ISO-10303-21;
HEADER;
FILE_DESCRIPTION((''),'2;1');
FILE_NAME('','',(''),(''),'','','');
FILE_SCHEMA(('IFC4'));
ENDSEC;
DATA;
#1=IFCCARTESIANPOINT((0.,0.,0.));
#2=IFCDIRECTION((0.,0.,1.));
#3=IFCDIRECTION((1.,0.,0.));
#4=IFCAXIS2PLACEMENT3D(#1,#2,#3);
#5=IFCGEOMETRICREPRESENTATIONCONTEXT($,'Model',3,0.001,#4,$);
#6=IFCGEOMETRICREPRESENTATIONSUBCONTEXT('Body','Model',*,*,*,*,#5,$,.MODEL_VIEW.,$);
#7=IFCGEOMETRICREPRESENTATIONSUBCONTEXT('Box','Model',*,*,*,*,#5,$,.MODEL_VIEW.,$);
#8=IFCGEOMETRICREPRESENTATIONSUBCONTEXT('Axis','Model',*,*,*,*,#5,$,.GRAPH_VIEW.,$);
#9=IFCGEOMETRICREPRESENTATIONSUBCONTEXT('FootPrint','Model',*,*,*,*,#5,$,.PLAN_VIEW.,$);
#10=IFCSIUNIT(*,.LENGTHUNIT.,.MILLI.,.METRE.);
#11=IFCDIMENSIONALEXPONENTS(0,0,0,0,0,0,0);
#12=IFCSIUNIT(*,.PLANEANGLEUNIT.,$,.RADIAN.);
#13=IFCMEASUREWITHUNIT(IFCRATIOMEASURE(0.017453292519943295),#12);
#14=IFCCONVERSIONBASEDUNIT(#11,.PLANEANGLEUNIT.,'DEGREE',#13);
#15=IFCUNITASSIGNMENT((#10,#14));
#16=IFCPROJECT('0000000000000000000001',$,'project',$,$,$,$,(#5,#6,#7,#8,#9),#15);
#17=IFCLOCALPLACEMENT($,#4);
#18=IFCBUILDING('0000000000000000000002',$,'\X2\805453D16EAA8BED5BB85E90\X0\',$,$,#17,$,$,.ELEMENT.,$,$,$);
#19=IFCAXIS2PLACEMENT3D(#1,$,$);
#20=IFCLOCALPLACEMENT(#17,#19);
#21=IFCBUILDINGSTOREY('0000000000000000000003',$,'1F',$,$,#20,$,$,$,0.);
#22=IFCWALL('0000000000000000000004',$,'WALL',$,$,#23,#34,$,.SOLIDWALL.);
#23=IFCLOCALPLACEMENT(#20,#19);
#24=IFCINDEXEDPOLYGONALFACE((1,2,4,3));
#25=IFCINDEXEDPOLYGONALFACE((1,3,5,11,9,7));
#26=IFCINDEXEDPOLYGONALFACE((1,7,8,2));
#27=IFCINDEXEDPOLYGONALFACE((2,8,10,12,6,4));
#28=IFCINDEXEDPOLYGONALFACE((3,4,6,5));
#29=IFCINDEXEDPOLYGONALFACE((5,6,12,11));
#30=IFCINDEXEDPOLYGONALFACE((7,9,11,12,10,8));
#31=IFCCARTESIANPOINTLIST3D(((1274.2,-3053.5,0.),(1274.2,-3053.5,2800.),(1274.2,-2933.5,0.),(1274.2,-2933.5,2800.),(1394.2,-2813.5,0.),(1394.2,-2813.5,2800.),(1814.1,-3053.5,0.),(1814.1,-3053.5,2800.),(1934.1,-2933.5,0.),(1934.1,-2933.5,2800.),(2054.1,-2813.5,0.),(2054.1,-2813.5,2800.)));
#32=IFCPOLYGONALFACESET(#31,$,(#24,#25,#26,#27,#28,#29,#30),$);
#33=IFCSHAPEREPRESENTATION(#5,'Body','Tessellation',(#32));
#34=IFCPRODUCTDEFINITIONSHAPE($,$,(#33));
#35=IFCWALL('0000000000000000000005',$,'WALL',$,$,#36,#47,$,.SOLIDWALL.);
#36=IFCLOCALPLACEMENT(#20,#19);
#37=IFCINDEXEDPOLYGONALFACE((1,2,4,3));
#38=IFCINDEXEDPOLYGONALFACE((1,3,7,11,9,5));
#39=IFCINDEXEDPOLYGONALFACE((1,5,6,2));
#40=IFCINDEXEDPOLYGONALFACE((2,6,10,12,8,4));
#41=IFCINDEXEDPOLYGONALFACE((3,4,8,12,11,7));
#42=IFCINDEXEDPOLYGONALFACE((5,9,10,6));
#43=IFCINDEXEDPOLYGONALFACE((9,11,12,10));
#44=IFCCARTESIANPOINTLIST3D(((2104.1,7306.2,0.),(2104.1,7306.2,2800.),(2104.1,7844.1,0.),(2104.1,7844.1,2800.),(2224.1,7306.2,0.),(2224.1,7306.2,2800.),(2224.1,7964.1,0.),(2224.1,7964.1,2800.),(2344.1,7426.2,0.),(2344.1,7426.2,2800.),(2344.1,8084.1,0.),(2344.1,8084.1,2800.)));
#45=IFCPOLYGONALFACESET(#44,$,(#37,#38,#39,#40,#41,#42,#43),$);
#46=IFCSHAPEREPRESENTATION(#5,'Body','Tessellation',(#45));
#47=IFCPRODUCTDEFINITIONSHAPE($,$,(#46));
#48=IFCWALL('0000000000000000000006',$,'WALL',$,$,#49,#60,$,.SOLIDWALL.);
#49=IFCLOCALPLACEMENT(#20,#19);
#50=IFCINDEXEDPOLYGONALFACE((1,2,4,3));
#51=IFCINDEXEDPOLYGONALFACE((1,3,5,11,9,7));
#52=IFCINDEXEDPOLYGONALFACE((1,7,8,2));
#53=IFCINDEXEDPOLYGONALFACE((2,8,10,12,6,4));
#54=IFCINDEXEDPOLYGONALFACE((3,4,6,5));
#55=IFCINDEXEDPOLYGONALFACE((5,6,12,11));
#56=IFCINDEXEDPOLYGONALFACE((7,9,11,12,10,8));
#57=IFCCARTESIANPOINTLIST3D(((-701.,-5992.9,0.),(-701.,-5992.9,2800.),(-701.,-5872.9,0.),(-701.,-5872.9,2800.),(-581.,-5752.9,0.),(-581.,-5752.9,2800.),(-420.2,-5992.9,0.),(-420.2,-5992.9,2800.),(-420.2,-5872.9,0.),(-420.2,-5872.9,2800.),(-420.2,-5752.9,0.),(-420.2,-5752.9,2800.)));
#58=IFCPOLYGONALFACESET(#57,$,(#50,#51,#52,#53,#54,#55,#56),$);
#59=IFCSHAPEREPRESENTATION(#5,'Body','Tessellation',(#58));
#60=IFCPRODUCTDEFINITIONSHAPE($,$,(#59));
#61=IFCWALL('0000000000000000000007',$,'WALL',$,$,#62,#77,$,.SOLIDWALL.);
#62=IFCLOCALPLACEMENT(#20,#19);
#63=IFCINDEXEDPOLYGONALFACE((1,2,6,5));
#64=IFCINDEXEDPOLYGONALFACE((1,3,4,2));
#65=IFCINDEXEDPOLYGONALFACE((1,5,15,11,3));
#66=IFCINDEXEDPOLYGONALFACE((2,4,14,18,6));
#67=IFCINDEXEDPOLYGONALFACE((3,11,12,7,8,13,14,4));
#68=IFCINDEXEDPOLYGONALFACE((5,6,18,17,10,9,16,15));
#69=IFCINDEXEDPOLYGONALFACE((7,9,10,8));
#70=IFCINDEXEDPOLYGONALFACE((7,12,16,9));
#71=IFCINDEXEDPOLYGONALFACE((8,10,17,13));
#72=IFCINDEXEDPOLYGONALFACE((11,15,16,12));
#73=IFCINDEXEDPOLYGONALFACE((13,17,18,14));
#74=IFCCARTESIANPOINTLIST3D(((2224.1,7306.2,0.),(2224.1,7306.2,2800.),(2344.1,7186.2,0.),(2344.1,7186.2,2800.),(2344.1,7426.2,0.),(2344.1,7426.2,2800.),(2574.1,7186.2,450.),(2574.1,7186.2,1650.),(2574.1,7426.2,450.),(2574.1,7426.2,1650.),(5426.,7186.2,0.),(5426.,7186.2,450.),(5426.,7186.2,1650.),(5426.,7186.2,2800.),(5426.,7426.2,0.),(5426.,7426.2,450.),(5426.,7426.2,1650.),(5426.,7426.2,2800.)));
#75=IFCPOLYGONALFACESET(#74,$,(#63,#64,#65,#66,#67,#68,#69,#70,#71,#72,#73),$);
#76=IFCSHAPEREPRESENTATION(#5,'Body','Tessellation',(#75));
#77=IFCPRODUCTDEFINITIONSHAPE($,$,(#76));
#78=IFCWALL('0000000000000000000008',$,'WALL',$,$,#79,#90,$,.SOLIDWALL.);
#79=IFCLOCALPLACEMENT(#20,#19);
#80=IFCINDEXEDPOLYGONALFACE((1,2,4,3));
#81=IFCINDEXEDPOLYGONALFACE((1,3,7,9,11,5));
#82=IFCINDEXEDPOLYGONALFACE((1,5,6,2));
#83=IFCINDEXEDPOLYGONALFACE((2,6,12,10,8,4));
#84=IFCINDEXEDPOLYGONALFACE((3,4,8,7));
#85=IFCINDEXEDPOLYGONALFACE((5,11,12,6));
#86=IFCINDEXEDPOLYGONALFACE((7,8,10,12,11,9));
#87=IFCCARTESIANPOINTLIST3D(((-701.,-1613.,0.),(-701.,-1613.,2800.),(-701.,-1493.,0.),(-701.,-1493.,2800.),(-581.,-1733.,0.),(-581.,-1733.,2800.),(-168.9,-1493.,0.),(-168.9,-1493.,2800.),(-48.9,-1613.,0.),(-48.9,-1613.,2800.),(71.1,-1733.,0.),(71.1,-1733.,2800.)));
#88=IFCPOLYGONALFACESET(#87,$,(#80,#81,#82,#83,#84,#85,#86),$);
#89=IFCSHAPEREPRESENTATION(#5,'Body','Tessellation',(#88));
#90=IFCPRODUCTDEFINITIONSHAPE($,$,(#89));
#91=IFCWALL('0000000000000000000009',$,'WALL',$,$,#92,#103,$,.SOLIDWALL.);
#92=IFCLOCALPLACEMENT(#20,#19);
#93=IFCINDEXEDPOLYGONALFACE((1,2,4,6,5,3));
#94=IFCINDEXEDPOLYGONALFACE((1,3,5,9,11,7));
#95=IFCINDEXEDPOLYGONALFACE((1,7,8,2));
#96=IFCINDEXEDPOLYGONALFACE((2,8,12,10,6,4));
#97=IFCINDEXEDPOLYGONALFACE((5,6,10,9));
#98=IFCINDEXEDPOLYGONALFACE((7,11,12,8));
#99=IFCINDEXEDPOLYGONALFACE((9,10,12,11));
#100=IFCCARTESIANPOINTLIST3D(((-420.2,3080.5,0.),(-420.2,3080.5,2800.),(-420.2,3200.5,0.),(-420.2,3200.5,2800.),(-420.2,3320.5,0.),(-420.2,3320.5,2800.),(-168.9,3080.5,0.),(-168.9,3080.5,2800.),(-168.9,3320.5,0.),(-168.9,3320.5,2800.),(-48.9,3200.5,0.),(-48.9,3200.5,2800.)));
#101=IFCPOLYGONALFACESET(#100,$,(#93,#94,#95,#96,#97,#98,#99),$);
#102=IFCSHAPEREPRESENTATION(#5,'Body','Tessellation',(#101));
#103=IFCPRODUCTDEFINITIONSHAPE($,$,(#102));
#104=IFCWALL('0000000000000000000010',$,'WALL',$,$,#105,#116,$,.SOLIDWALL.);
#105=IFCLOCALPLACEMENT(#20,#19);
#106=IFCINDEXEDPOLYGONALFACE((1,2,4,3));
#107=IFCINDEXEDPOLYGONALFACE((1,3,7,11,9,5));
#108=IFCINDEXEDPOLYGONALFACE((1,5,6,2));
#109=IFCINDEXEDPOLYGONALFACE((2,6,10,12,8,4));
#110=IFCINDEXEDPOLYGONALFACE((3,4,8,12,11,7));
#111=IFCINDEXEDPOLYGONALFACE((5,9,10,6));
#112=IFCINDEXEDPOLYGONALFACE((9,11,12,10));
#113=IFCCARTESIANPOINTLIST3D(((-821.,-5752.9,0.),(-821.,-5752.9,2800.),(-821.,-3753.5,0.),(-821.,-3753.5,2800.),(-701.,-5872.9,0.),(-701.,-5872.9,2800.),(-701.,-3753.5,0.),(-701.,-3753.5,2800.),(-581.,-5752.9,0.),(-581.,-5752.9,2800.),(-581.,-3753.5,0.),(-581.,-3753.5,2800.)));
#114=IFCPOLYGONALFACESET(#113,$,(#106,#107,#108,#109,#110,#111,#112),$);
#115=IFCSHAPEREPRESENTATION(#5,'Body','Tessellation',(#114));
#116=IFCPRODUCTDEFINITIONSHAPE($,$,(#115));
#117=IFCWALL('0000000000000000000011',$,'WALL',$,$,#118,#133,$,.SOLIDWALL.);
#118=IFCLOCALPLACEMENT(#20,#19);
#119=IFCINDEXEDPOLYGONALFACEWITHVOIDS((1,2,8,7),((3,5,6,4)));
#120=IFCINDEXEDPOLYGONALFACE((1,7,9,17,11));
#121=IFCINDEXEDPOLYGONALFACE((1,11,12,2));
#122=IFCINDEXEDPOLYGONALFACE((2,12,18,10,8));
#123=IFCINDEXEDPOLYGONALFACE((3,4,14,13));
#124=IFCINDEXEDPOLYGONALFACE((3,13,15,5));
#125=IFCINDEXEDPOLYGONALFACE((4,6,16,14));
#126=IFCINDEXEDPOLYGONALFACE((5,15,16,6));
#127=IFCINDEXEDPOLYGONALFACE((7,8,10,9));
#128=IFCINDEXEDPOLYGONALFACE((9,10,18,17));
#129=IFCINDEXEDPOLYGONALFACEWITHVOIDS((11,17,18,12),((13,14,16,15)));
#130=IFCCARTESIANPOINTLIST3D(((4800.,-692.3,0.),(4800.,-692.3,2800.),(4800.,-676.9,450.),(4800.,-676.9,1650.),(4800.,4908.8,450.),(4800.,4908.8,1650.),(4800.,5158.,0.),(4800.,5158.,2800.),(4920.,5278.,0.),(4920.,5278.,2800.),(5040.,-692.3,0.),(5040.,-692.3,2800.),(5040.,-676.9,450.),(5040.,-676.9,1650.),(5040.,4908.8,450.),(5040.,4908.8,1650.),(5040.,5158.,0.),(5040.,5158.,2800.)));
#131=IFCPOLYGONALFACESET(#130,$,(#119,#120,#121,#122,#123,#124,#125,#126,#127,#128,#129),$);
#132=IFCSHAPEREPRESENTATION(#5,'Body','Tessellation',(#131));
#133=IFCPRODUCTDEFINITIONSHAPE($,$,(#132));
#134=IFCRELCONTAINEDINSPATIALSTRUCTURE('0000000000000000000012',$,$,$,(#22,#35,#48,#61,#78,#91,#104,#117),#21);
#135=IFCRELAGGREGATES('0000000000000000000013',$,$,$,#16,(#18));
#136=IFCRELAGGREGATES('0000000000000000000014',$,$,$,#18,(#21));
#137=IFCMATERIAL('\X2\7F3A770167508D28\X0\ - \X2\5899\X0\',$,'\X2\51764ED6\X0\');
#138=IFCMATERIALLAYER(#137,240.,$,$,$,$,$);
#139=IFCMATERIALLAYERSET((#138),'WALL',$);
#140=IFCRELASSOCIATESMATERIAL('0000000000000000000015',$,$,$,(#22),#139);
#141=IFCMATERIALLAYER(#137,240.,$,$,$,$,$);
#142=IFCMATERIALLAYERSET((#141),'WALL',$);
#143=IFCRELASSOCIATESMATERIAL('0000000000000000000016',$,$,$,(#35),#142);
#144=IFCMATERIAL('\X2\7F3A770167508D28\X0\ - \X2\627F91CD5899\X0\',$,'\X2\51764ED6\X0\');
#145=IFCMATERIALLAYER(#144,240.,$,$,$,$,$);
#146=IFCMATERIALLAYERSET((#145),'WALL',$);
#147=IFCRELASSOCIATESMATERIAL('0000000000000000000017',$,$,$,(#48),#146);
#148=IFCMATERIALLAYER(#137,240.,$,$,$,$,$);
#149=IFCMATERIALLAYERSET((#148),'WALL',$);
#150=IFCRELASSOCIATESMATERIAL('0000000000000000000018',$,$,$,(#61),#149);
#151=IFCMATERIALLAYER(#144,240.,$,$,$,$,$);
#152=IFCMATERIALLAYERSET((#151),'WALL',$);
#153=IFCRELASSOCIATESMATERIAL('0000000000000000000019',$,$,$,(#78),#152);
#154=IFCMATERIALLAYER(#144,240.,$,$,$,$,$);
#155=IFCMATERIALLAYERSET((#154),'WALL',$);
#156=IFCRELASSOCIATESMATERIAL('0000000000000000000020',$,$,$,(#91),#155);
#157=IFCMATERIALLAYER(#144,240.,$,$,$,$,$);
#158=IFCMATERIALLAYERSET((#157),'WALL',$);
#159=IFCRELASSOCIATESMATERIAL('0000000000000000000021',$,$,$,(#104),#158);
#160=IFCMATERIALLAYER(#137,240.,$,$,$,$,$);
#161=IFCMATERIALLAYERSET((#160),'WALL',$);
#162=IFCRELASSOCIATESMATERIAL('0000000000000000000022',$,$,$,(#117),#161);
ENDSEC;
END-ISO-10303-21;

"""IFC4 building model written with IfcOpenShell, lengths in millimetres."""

from ifc_helpers import new_model, entity, si_unit, converted_unit, frame, origin, origin_with_axes, place, context, subcontext, project, spatial, polyline, segment, composite_curve, outline, extrude, material, layer, layer_set, layer_usage, element, save


model = new_model("IFC4")

# Units and contexts
model_context = context("Model", 3, precision=0.001, world=origin_with_axes())
body_context = subcontext(model_context, "Body", "Model", "MODEL_VIEW")
box_context = subcontext(model_context, "Box", "Model", "MODEL_VIEW")
axis_context = subcontext(model_context, "Axis", "Model", "GRAPH_VIEW")
footprint_context = subcontext(model_context, "FootPrint", "Model", "PLAN_VIEW")
ifc_project = project(units=[si_unit("LENGTHUNIT", "METRE", prefix="MILLI"), converted_unit("PLANEANGLEUNIT", "DEGREE", entity("IfcRatioMeasure", 0.017453292519943295), si_unit("PLANEANGLEUNIT", "RADIAN"), dimensions=[0, 0, 0, 0, 0, 0, 0])], contexts=[model_context, body_context, box_context, axis_context, footprint_context])

# Building, storey
building_placement = place(None, origin_with_axes())
building = spatial("IfcBuilding", under=ifc_project, at=building_placement, Name="联发溪语宸庐", CompositionType="ELEMENT")
storey_placement = place(building_placement, origin())
storey = spatial("IfcBuildingStorey", under=building, at=storey_placement, Name="1F", Elevation=0.0)

# Shared definitions
ifc_material_1 = material(Name="缺省材质 - 承重墙", Category="其他")

# Shared definitions
ifc_material_2 = material(Name="缺省材质 - 墙", Category="其他")

# Walls
ifc_layer_1 = layer(ifc_material_2, 240.0)
ifc_layer_set_1 = layer_set([ifc_layer_1], Name="WALL")
ifc_layer_usage_1 = layer_usage(ifc_layer_set_1, "AXIS2", "NEGATIVE", 120.0)
wall_1_placement = place(None, origin_with_axes())
element("IfcWall", 1, at=wall_1_placement, inside=storey, material=ifc_layer_usage_1, Name="WALL", PredefinedType="SOLIDWALL", context=model_context, shape_type="SweptSolid", body=[
    extrude(outline(composite_curve([segment(polyline([(1274.2, -2933.5), (1274.2, -3053.5)]), True, "CONTINUOUS"), segment(polyline([(1274.2, -3053.5), (1814.1, -3053.5)]), True, "CONTINUOUS"), segment(polyline([(1814.1, -3053.5), (1934.1, -2933.5)]), True, "CONTINUOUS"), segment(polyline([(1934.1, -2933.5), (2054.1, -2813.5)]), True, "CONTINUOUS"), segment(polyline([(2054.1, -2813.5), (1394.2, -2813.5)]), True, "CONTINUOUS"), segment(polyline([(1394.2, -2813.5), (1274.2, -2933.5)]), True, "CONTINUOUS")], self_intersect=False)), origin(), (0.0, 0.0, 1.0), 2800.0),
])
ifc_layer_2 = layer(ifc_material_2, 240.0)
ifc_layer_set_2 = layer_set([ifc_layer_2], Name="WALL")
ifc_layer_usage_2 = layer_usage(ifc_layer_set_2, "AXIS2", "NEGATIVE", 120.0)
wall_2_placement = place(None, origin_with_axes())
element("IfcWall", 2, at=wall_2_placement, inside=storey, material=ifc_layer_usage_2, Name="WALL", PredefinedType="SOLIDWALL", context=model_context, shape_type="SweptSolid", body=[
    extrude(outline(composite_curve([segment(polyline([(2224.1, 7964.1), (2104.1, 7844.1)]), True, "CONTINUOUS"), segment(polyline([(2104.1, 7844.1), (2104.1, 7306.2)]), True, "CONTINUOUS"), segment(polyline([(2104.1, 7306.2), (2224.1, 7306.2)]), True, "CONTINUOUS"), segment(polyline([(2224.1, 7306.2), (2344.1, 7426.2)]), True, "CONTINUOUS"), segment(polyline([(2344.1, 7426.2), (2344.1, 8084.1)]), True, "CONTINUOUS"), segment(polyline([(2344.1, 8084.1), (2224.1, 7964.1)]), True, "CONTINUOUS")], self_intersect=False)), origin(), (0.0, 0.0, 1.0), 2800.0),
])
ifc_layer_3 = layer(ifc_material_1, 240.0)
ifc_layer_set_3 = layer_set([ifc_layer_3], Name="WALL")
ifc_layer_usage_3 = layer_usage(ifc_layer_set_3, "AXIS2", "NEGATIVE", 120.0)
wall_3_placement = place(None, origin_with_axes())
element("IfcWall", 3, at=wall_3_placement, inside=storey, material=ifc_layer_usage_3, Name="WALL", PredefinedType="SOLIDWALL", context=model_context, shape_type="SweptSolid", body=[
    extrude(outline(composite_curve([segment(polyline([(-701.0, -5872.9), (-701.0, -5992.9)]), True, "CONTINUOUS"), segment(polyline([(-701.0, -5992.9), (-420.2, -5992.9)]), True, "CONTINUOUS"), segment(polyline([(-420.2, -5992.9), (-420.2, -5872.9)]), True, "CONTINUOUS"), segment(polyline([(-420.2, -5872.9), (-420.2, -5752.9)]), True, "CONTINUOUS"), segment(polyline([(-420.2, -5752.9), (-581.0, -5752.9)]), True, "CONTINUOUS"), segment(polyline([(-581.0, -5752.9), (-701.0, -5872.9)]), True, "CONTINUOUS")], self_intersect=False)), origin(), (0.0, 0.0, 1.0), 2800.0),
])

# Wall, opening
ifc_layer_4 = layer(ifc_material_2, 240.0)
ifc_layer_set_4 = layer_set([ifc_layer_4], Name="WALL")
ifc_layer_usage_4 = layer_usage(ifc_layer_set_4, "AXIS2", "NEGATIVE", 120.0)
wall_4_placement = place(None, origin_with_axes())
wall_4 = element("IfcWall", 4, at=wall_4_placement, inside=storey, material=ifc_layer_usage_4, Name="WALL", PredefinedType="SOLIDWALL", context=model_context, shape_type="SweptSolid", body=[
    extrude(outline(composite_curve([segment(polyline([(5426.0, 7306.2), (5426.0, 7426.2)]), True, "CONTINUOUS"), segment(polyline([(5426.0, 7426.2), (2344.1, 7426.2)]), True, "CONTINUOUS"), segment(polyline([(2344.1, 7426.2), (2224.1, 7306.2)]), True, "CONTINUOUS"), segment(polyline([(2224.1, 7306.2), (2344.1, 7186.2)]), True, "CONTINUOUS"), segment(polyline([(2344.1, 7186.2), (5426.0, 7186.2)]), True, "CONTINUOUS"), segment(polyline([(5426.0, 7186.2), (5426.0, 7306.2)]), True, "CONTINUOUS")], self_intersect=False)), origin(), (0.0, 0.0, 1.0), 2800.0),
])
opening_1_placement = place(None, origin_with_axes())
element("IfcOpeningElement", 5, at=opening_1_placement, cuts=wall_4, ObjectType="OPENING", PredefinedType="OPENING", context=model_context, shape_type="SweptSolid", body=[
    extrude(outline(composite_curve([segment(polyline([(2574.1, 7186.2), (5426.0, 7186.2)]), True, "CONTINUOUS"), segment(polyline([(5426.0, 7186.2), (5426.0, 7426.2)]), True, "CONTINUOUS"), segment(polyline([(5426.0, 7426.2), (2574.1, 7426.2)]), True, "CONTINUOUS"), segment(polyline([(2574.1, 7426.2), (2574.1, 7186.2)]), True, "CONTINUOUS")], self_intersect=False)), frame((0.0, 0.0, 450.0), z_axis=(0.0, 0.0, 1.0), x_axis=(1.0, 0.0, 0.0)), (0.0, 0.0, 1.0), 1200.0),
])

# Walls
ifc_layer_5 = layer(ifc_material_1, 240.0)
ifc_layer_set_5 = layer_set([ifc_layer_5], Name="WALL")
ifc_layer_usage_5 = layer_usage(ifc_layer_set_5, "AXIS2", "NEGATIVE", 120.0)
wall_5_placement = place(None, origin_with_axes())
element("IfcWall", 6, at=wall_5_placement, inside=storey, material=ifc_layer_usage_5, Name="WALL", PredefinedType="SOLIDWALL", context=model_context, shape_type="SweptSolid", body=[
    extrude(outline(composite_curve([segment(polyline([(-701.0, -1613.0), (-581.0, -1733.0)]), True, "CONTINUOUS"), segment(polyline([(-581.0, -1733.0), (71.1, -1733.0)]), True, "CONTINUOUS"), segment(polyline([(71.1, -1733.0), (-48.9, -1613.0)]), True, "CONTINUOUS"), segment(polyline([(-48.9, -1613.0), (-168.9, -1493.0)]), True, "CONTINUOUS"), segment(polyline([(-168.9, -1493.0), (-701.0, -1493.0)]), True, "CONTINUOUS"), segment(polyline([(-701.0, -1493.0), (-701.0, -1613.0)]), True, "CONTINUOUS")], self_intersect=False)), origin(), (0.0, 0.0, 1.0), 2800.0),
])
ifc_layer_6 = layer(ifc_material_1, 240.0)
ifc_layer_set_6 = layer_set([ifc_layer_6], Name="WALL")
ifc_layer_usage_6 = layer_usage(ifc_layer_set_6, "AXIS2", "NEGATIVE", 120.0)
wall_6_placement = place(None, origin_with_axes())
element("IfcWall", 7, at=wall_6_placement, inside=storey, material=ifc_layer_usage_6, Name="WALL", PredefinedType="SOLIDWALL", context=model_context, shape_type="SweptSolid", body=[
    extrude(outline(composite_curve([segment(polyline([(-48.9, 3200.5), (-168.9, 3320.5)]), True, "CONTINUOUS"), segment(polyline([(-168.9, 3320.5), (-420.2, 3320.5)]), True, "CONTINUOUS"), segment(polyline([(-420.2, 3320.5), (-420.2, 3200.5)]), True, "CONTINUOUS"), segment(polyline([(-420.2, 3200.5), (-420.2, 3080.5)]), True, "CONTINUOUS"), segment(polyline([(-420.2, 3080.5), (-168.9, 3080.5)]), True, "CONTINUOUS"), segment(polyline([(-168.9, 3080.5), (-48.9, 3200.5)]), True, "CONTINUOUS")], self_intersect=False)), origin(), (0.0, 0.0, 1.0), 2800.0),
])
ifc_layer_7 = layer(ifc_material_1, 240.0)
ifc_layer_set_7 = layer_set([ifc_layer_7], Name="WALL")
ifc_layer_usage_7 = layer_usage(ifc_layer_set_7, "AXIS2", "NEGATIVE", 120.0)
wall_7_placement = place(None, origin_with_axes())
element("IfcWall", 8, at=wall_7_placement, inside=storey, material=ifc_layer_usage_7, Name="WALL", PredefinedType="SOLIDWALL", context=model_context, shape_type="SweptSolid", body=[
    extrude(outline(composite_curve([segment(polyline([(-701.0, -5872.9), (-581.0, -5752.9)]), True, "CONTINUOUS"), segment(polyline([(-581.0, -5752.9), (-581.0, -3753.5)]), True, "CONTINUOUS"), segment(polyline([(-581.0, -3753.5), (-701.0, -3753.5)]), True, "CONTINUOUS"), segment(polyline([(-701.0, -3753.5), (-821.0, -3753.5)]), True, "CONTINUOUS"), segment(polyline([(-821.0, -3753.5), (-821.0, -5752.9)]), True, "CONTINUOUS"), segment(polyline([(-821.0, -5752.9), (-701.0, -5872.9)]), True, "CONTINUOUS")], self_intersect=False)), origin(), (0.0, 0.0, 1.0), 2800.0),
])

# Wall, opening
ifc_layer_8 = layer(ifc_material_2, 240.0)
ifc_layer_set_8 = layer_set([ifc_layer_8], Name="WALL")
ifc_layer_usage_8 = layer_usage(ifc_layer_set_8, "AXIS2", "NEGATIVE", 120.0)
wall_8_placement = place(None, origin_with_axes())
wall_8 = element("IfcWall", 9, at=wall_8_placement, inside=storey, material=ifc_layer_usage_8, Name="WALL", PredefinedType="SOLIDWALL", context=model_context, shape_type="SweptSolid", body=[
    extrude(outline(composite_curve([segment(polyline([(4920.0, -692.3), (5040.0, -692.3)]), True, "CONTINUOUS"), segment(polyline([(5040.0, -692.3), (5040.0, 5158.0)]), True, "CONTINUOUS"), segment(polyline([(5040.0, 5158.0), (4920.0, 5278.0)]), True, "CONTINUOUS"), segment(polyline([(4920.0, 5278.0), (4800.0, 5158.0)]), True, "CONTINUOUS"), segment(polyline([(4800.0, 5158.0), (4800.0, -692.3)]), True, "CONTINUOUS"), segment(polyline([(4800.0, -692.3), (4920.0, -692.3)]), True, "CONTINUOUS")], self_intersect=False)), origin(), (0.0, 0.0, 1.0), 2800.0),
])
opening_2_placement = place(None, origin_with_axes())
element("IfcOpeningElement", 10, at=opening_2_placement, cuts=wall_8, ObjectType="OPENING", PredefinedType="OPENING", context=model_context, shape_type="SweptSolid", body=[
    extrude(outline(composite_curve([segment(polyline([(4800.0, 4908.8), (4800.0, -676.9)]), True, "CONTINUOUS"), segment(polyline([(4800.0, -676.9), (5040.0, -676.9)]), True, "CONTINUOUS"), segment(polyline([(5040.0, -676.9), (5040.0, 4908.8)]), True, "CONTINUOUS"), segment(polyline([(5040.0, 4908.8), (4800.0, 4908.8)]), True, "CONTINUOUS")], self_intersect=False)), frame((0.0, 0.0, 450.0), z_axis=(0.0, 0.0, 1.0), x_axis=(1.0, 0.0, 0.0)), (0.0, 0.0, 1.0), 1200.0),
])

save(model, "model.ifc")
